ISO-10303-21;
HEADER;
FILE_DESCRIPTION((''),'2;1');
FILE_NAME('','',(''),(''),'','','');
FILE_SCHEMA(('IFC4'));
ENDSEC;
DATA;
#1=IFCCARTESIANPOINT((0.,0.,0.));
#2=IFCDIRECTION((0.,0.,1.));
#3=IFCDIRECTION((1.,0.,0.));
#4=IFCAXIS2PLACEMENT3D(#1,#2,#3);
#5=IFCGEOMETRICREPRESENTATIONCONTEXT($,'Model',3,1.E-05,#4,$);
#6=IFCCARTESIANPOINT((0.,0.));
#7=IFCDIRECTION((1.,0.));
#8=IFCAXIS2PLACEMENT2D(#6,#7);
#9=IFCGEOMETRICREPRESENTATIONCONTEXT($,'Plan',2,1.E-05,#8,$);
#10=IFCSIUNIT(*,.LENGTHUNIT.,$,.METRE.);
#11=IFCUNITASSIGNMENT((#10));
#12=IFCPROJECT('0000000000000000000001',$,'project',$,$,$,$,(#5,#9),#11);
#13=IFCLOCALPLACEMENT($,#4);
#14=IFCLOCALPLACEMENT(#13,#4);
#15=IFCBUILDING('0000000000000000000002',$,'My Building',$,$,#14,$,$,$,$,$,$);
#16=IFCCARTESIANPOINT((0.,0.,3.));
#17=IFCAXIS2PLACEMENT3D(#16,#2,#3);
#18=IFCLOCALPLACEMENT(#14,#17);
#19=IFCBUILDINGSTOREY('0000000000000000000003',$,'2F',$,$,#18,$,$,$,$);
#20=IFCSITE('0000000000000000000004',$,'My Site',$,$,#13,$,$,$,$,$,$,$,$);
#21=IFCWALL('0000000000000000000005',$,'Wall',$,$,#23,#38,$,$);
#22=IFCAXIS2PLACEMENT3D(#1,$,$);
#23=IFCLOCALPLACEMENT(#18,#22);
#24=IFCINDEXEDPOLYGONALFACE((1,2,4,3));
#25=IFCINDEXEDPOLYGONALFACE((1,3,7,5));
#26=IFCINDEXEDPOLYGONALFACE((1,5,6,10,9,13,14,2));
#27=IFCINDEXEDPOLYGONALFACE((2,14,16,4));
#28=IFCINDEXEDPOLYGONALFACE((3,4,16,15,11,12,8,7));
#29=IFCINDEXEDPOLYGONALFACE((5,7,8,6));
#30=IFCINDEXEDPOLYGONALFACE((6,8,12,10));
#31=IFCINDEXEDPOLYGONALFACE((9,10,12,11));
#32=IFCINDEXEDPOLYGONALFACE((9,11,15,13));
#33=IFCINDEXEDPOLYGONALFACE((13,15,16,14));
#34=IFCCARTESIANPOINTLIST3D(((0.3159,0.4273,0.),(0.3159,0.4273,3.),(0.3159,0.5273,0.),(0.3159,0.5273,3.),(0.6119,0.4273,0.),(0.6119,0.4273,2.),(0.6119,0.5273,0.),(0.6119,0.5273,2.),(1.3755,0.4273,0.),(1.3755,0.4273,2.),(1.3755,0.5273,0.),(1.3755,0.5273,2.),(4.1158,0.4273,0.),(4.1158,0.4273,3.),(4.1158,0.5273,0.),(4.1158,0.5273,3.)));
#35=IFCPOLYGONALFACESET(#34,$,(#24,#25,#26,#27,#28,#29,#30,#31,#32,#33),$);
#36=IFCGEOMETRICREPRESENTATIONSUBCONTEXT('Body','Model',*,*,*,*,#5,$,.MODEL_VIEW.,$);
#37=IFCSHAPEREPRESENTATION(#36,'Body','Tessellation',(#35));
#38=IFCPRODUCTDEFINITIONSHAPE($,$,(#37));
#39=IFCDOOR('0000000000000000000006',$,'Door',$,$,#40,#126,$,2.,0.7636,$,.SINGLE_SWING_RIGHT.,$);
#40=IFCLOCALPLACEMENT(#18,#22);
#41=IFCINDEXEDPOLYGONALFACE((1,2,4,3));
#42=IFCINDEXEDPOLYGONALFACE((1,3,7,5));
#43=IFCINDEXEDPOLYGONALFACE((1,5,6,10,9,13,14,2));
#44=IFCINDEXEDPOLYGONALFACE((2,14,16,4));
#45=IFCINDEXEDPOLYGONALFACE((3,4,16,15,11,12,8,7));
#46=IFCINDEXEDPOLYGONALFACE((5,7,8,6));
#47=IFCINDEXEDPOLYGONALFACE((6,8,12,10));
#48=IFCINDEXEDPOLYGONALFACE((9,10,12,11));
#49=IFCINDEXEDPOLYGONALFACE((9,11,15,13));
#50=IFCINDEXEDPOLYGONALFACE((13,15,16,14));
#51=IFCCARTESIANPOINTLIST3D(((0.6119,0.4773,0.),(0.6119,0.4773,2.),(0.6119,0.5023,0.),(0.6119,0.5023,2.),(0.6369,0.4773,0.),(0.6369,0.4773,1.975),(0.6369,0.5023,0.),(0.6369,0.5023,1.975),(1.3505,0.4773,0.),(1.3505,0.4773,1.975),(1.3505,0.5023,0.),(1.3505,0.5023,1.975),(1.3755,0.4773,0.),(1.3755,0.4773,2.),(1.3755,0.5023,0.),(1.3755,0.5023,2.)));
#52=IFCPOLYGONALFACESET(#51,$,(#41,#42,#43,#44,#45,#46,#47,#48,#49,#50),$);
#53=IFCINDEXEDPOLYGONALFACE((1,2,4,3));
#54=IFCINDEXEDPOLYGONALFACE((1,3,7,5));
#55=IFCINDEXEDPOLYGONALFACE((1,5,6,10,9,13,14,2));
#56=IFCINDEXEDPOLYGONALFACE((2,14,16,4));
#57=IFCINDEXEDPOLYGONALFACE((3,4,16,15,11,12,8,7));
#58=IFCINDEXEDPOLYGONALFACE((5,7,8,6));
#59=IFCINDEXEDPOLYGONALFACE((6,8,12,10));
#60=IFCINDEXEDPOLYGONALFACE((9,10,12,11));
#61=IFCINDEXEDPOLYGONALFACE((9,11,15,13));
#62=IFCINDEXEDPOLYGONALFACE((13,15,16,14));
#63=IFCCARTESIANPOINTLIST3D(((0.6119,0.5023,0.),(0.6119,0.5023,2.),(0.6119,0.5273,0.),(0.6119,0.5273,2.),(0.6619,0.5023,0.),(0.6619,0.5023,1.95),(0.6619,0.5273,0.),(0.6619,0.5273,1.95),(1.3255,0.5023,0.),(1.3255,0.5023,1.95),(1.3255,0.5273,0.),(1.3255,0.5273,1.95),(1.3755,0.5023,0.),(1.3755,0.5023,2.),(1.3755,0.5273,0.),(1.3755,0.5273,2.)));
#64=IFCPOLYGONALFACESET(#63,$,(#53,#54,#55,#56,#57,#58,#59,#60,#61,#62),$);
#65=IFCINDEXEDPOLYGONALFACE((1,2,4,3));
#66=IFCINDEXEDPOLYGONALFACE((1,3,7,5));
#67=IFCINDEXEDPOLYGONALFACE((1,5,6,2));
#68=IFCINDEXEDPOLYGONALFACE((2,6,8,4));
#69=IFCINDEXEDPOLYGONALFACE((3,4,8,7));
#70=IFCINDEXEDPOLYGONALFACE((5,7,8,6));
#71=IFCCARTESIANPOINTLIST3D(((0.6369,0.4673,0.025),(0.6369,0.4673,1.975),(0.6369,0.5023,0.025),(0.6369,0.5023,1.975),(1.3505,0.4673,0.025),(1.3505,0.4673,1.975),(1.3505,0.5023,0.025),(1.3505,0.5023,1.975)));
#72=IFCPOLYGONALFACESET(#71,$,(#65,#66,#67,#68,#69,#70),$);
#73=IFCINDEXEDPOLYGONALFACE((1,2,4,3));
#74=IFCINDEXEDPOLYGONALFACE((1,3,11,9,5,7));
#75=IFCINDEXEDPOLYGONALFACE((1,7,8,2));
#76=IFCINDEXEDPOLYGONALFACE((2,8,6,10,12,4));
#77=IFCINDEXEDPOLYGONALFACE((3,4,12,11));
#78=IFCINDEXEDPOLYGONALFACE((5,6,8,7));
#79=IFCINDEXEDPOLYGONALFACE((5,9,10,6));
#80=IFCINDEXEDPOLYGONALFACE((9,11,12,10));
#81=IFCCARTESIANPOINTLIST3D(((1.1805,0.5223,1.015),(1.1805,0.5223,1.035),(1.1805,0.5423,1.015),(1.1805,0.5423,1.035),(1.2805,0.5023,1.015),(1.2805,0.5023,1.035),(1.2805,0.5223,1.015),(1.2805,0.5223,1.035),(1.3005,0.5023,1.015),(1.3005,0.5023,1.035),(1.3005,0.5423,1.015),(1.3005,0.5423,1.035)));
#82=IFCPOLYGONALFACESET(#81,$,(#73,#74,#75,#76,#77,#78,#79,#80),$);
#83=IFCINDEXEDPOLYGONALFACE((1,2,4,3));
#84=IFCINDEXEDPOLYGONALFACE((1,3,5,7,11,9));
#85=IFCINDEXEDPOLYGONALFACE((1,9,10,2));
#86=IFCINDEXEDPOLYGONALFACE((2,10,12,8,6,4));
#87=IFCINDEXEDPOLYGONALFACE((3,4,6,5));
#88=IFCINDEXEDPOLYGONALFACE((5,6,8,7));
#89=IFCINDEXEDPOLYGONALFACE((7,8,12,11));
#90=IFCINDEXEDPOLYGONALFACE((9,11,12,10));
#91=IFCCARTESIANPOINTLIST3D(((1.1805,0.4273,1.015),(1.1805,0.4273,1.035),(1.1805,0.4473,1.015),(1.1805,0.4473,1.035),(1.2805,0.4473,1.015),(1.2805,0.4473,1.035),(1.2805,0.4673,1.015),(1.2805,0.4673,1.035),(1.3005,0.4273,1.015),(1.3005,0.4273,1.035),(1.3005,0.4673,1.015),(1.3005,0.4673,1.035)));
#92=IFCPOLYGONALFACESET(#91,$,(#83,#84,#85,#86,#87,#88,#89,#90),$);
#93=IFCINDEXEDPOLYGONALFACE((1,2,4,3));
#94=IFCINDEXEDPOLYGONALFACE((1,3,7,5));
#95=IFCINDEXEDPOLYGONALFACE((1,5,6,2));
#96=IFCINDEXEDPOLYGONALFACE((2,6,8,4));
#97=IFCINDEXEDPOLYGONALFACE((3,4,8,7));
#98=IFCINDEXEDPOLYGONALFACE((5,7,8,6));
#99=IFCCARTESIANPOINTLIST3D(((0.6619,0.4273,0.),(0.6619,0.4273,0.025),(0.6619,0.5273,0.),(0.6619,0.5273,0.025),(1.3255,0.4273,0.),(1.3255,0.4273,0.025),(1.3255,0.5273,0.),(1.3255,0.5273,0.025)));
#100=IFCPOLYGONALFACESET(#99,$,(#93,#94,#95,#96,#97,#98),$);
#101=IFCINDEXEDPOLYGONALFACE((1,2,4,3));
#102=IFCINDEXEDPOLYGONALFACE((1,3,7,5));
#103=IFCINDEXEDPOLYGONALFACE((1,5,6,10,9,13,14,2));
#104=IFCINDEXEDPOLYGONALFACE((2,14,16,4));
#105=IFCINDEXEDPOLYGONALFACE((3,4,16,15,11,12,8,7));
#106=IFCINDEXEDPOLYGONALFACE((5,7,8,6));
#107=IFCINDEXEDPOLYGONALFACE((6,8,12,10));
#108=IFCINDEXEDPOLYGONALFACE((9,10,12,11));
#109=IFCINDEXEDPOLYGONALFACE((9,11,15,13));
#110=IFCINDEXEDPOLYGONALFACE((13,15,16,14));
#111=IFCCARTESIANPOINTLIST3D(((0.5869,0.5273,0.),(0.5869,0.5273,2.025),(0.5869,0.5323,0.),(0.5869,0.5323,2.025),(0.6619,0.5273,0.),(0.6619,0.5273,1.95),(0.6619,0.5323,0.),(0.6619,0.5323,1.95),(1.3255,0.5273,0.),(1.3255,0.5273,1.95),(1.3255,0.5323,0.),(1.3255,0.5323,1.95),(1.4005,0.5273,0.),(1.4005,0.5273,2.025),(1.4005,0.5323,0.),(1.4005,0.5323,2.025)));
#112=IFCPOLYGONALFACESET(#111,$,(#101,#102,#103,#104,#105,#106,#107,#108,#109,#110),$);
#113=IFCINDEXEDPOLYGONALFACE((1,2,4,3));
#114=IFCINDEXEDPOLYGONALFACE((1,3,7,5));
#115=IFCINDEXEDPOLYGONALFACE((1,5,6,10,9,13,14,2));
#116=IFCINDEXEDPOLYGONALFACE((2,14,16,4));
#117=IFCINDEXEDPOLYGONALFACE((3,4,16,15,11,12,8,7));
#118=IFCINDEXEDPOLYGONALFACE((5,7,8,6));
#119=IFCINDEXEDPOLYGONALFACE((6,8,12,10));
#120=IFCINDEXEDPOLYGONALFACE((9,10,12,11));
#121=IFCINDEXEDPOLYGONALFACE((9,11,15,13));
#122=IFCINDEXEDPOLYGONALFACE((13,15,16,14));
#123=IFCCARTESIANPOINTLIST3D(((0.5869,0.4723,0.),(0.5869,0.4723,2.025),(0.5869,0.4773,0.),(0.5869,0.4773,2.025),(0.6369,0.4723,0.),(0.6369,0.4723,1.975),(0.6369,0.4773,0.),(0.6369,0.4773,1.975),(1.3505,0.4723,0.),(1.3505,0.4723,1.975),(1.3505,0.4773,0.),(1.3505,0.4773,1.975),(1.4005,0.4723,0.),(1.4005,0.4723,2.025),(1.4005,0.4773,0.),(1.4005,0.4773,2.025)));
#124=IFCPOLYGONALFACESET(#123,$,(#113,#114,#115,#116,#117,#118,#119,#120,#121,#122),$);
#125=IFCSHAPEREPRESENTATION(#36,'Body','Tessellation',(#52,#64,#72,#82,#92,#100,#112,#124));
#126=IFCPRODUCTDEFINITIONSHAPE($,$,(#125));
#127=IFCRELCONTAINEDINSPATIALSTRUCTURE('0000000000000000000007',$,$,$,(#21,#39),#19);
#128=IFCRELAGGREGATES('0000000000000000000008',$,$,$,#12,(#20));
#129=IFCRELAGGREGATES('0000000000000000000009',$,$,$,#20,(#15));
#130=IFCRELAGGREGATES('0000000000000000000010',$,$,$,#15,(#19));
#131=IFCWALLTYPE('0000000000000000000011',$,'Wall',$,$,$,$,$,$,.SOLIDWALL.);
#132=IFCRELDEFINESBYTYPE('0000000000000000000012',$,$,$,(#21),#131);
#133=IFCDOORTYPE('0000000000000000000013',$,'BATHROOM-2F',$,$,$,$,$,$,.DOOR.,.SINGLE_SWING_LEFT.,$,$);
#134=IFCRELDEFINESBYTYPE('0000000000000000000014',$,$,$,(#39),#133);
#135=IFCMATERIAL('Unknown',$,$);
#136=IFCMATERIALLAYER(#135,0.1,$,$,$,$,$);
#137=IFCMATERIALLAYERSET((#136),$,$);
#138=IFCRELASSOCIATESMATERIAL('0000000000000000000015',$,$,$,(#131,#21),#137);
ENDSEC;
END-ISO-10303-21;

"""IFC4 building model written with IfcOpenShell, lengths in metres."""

from ifc_helpers import new_model, entity, si_unit, frame, origin_with_axes, origin_2d_with_axis, place, context, subcontext, project, spatial, line, indexed_curve, outline, extrude, shape, source, transform, mapped, material, layer, layer_set, layer_usage, type_object, type_shapes, element, fill, save


model = new_model("IFC4")

# Units and contexts
model_context = context("Model", 3, precision=1e-05, world=origin_with_axes())
plan_context = context("Plan", 2, precision=1e-05, world=origin_2d_with_axis())
body_context_1 = subcontext(model_context, "Body", "Model", "MODEL_VIEW")
body_context_2 = subcontext(plan_context, "Body", "Plan", "PLAN_VIEW")
ifc_project = project(units=[si_unit("LENGTHUNIT", "METRE")], contexts=[model_context, plan_context])

# Site, building, storey
site_placement = place(None, origin_with_axes())
site = spatial("IfcSite", under=ifc_project, at=site_placement, Name="My Site")
building_placement = place(site_placement, origin_with_axes())
building = spatial("IfcBuilding", under=site, at=building_placement, Name="My Building")
storey_placement = place(building_placement, frame((0.0, 0.0, 3.0), z_axis=(0.0, 0.0, 1.0), x_axis=(1.0, 0.0, 0.0)))
storey = spatial("IfcBuildingStorey", under=building, at=storey_placement, Name="2F")

# Shared definitions
ifc_material_1 = material(Name="Unknown")

# Shared definitions
ifc_layer_1 = layer(ifc_material_1, 0.1)
ifc_layer_set_1 = layer_set([ifc_layer_1])
wall_type = type_object("IfcWallType", Name="Wall", PredefinedType="SOLIDWALL", material=ifc_layer_set_1)

# Wall, opening, door
ifc_layer_usage_1 = layer_usage(ifc_layer_set_1, "AXIS2", "POSITIVE", 0.0)
wall_1_placement = place(storey_placement, frame((0.3159, 0.4273, 0.0), z_axis=(0.0, 0.0, 1.0), x_axis=(1.0, 0.0, 0.0)))
wall_1 = element("IfcWall", 1, at=wall_1_placement, inside=storey, type_object=wall_type, material=ifc_layer_usage_1, Name="Wall", context=body_context_1, shape_type="SweptSolid", body=[
    extrude(outline(indexed_curve([(0.0, 0.0), (0.0, 0.1), (3.8, 0.1), (3.8, 0.0)], segments=[line(1, 2, 3, 4, 1)])), origin_with_axes(), (0.0, 0.0, 1.0), 3.0),
])
shared_shape_1 = source(origin_with_axes(), body_context_1, "Body", "SweptSolid", [
    extrude(outline(indexed_curve([(0.0, 0.0), (0.7636, 0.0), (0.7636, 2.0), (0.0, 2.0)], segments=[line(1, 2, 3, 4, 1)])), frame((0.0, -0.6, 0.0), z_axis=(0.0, -1.0, 0.0), x_axis=(1.0, 0.0, 0.0)), (0.0, 0.0, -1.0), 1.2),
])
opening_1_placement = place(wall_1_placement, frame((1.0596, 0.1, 0.0), z_axis=(0.0, 0.0, 1.0), x_axis=(-1.0, 0.0, 0.0)))
opening_1 = element("IfcOpeningElement", 2, at=opening_1_placement, cuts=wall_1, PredefinedType="OPENING", context=body_context_1, shape_type="MappedRepresentation", body=[
    mapped(shared_shape_1, transform((0.0, 0.0, 0.0), x_axis=(1.0, 0.0, 0.0), y_axis=(0.0, 1.0, 0.0), z_axis=(0.0, 0.0, 1.0), scale=1.0)),
])
door_type_1 = type_object("IfcDoorType", Name="BATHROOM-2F", OperationType="SINGLE_SWING_LEFT", PredefinedType="DOOR")
shared_shape_2 = source(origin_with_axes(), body_context_1, "Body", "SweptSolid", [
    extrude(outline(indexed_curve([(0.0, 0.0), (0.0, 2.0), (0.7636, 2.0), (0.7636, 0.0), (0.7386, 0.0), (0.7386, 1.975), (0.025, 1.975), (0.025, 0.0)], segments=[line(1, 2, 3, 4, 5, 6, 7, 8, 1)])), frame((0.0, 0.025, 0.0), z_axis=(0.0, -1.0, 0.0), x_axis=(1.0, 0.0, 0.0)), (0.0, 0.0, -1.0), 0.025),
    extrude(outline(indexed_curve([(0.0, 0.0), (0.0, 2.0), (0.7636, 2.0), (0.7636, 0.0), (0.7136, 0.0), (0.7136, 1.95), (0.05, 1.95), (0.05, 0.0)], segments=[line(1, 2, 3, 4, 5, 6, 7, 8, 1)])), frame((0.0, 0.0, 0.0), z_axis=(0.0, -1.0, 0.0), x_axis=(1.0, 0.0, 0.0)), (0.0, 0.0, -1.0), 0.025),
    extrude(outline(indexed_curve([(0.0, 0.0), (0.7136, 0.0), (0.7136, 0.035), (0.0, 0.035)], segments=[line(1, 2, 3, 4, 1)])), frame((0.025, 0.025, 0.025), z_axis=(0.0, 0.0, 1.0), x_axis=(1.0, 0.0, 0.0)), (0.0, 0.0, 1.0), 1.95),
    extrude(outline(indexed_curve([(0.0, 0.0), (0.0, -0.04), (0.12, -0.04), (0.12, -0.02), (0.02, -0.02), (0.02, 0.0)], segments=[line(1, 2, 3, 4, 5, 6, 1)])), frame((0.075, 0.025, 1.015), z_axis=(0.0, 0.0, 1.0), x_axis=(1.0, 0.0, 0.0)), (0.0, 0.0, 1.0), 0.02),
    extrude(outline(indexed_curve([(0.0, 0.0), (0.0, 0.04), (0.12, 0.04), (0.12, 0.02), (0.02, 0.02), (0.02, 0.0)], segments=[line(1, 2, 3, 4, 5, 6, 1)])), frame((0.075, 0.06, 1.015), z_axis=(0.0, 0.0, 1.0), x_axis=(1.0, 0.0, 0.0)), (0.0, 0.0, 1.0), 0.02),
    extrude(outline(indexed_curve([(0.0, 0.0), (0.6636, 0.0), (0.6636, 0.1), (0.0, 0.1)], segments=[line(1, 2, 3, 4, 1)])), frame((0.05, 0.0, 0.0), z_axis=(0.0, 0.0, 1.0), x_axis=(1.0, 0.0, 0.0)), (0.0, 0.0, 1.0), 0.025),
    extrude(outline(indexed_curve([(0.0, 0.0), (0.0, 2.025), (0.8136, 2.025), (0.8136, 0.0), (0.7386, 0.0), (0.7386, 1.95), (0.075, 1.95), (0.075, 0.0)], segments=[line(1, 2, 3, 4, 5, 6, 7, 8, 1)])), frame((-0.025, -0.005, 0.0), z_axis=(0.0, -1.0, 0.0), x_axis=(1.0, 0.0, 0.0)), (0.0, 0.0, -1.0), 0.005),
    extrude(outline(indexed_curve([(0.0, 0.0), (0.0, 2.025), (0.8136, 2.025), (0.8136, 0.0), (0.7636, 0.0), (0.7636, 1.975), (0.05, 1.975), (0.05, 0.0)], segments=[line(1, 2, 3, 4, 5, 6, 7, 8, 1)])), frame((-0.025, 0.05, 0.0), z_axis=(0.0, -1.0, 0.0), x_axis=(1.0, 0.0, 0.0)), (0.0, 0.0, -1.0), 0.005),
])
shared_shape_3 = source(origin_with_axes(), body_context_2, "Body", "Curve2D", [
    entity("IfcIndexedPolyCurve", entity("IfcCartesianPointList2D", [[0.0, 0.0], [0.0, 0.05], [0.025, 0.05], [0.025, 0.025], [0.05, 0.025], [0.05, 0.0]]), [entity("IfcLineIndex", [1, 2, 3, 4, 5, 6, 1])]),
    entity("IfcIndexedPolyCurve", entity("IfcCartesianPointList2D", [[0.7636, 0.0], [0.7636, 0.05], [0.7386, 0.05], [0.7386, 0.025], [0.7136, 0.025], [0.7136, 0.0]]), [entity("IfcLineIndex", [1, 2, 3, 4, 5, 6, 1])]),
    entity("IfcTrimmedCurve", entity("IfcEllipse", entity("IfcAxis2Placement2D", entity("IfcCartesianPoint", [0.7036, 0.05]), entity("IfcDirection", [1.0, 0.0])), 0.6786, 0.7136), [entity("IfcCartesianPoint", [0.7036, 0.7636])], [entity("IfcCartesianPoint", [0.025, 0.05])], True, "CARTESIAN"),
    entity("IfcIndexedPolyCurve", entity("IfcCartesianPointList2D", [[0.7386, 0.05], [0.7036, 0.05], [0.7036, 0.7636], [0.7386, 0.7636]]), [entity("IfcLineIndex", [1, 2, 3, 4, 1])]),
])
type_shapes(door_type_1, [shared_shape_2, shared_shape_3])
door_1_placement = place(opening_1_placement, frame((0.0, 0.0, 0.0), z_axis=(0.0, 0.0, 1.0), x_axis=(1.0, 0.0, 0.0)))
door_1 = element("IfcDoor", 3, at=door_1_placement, inside=storey, type_object=door_type_1, Name="Door", OperationType="SINGLE_SWING_RIGHT", OverallHeight=2.0, OverallWidth=0.7636, shapes=[
    shape(body_context_1, "Body", "MappedRepresentation", [mapped(shared_shape_2, transform((0.0, 0.0, 0.0), x_axis=(1.0, 0.0, 0.0), y_axis=(0.0, 1.0, 0.0), z_axis=(0.0, 0.0, 1.0), scale=1.0))]),
    shape(body_context_2, "Body", "MappedRepresentation", [mapped(shared_shape_3, transform((0.0, 0.0, 0.0), x_axis=(1.0, 0.0, 0.0), y_axis=(0.0, 1.0, 0.0), z_axis=(0.0, 0.0, 1.0), scale=1.0))]),
])
fill(opening_1, door_1)

save(model, "model.ifc")
